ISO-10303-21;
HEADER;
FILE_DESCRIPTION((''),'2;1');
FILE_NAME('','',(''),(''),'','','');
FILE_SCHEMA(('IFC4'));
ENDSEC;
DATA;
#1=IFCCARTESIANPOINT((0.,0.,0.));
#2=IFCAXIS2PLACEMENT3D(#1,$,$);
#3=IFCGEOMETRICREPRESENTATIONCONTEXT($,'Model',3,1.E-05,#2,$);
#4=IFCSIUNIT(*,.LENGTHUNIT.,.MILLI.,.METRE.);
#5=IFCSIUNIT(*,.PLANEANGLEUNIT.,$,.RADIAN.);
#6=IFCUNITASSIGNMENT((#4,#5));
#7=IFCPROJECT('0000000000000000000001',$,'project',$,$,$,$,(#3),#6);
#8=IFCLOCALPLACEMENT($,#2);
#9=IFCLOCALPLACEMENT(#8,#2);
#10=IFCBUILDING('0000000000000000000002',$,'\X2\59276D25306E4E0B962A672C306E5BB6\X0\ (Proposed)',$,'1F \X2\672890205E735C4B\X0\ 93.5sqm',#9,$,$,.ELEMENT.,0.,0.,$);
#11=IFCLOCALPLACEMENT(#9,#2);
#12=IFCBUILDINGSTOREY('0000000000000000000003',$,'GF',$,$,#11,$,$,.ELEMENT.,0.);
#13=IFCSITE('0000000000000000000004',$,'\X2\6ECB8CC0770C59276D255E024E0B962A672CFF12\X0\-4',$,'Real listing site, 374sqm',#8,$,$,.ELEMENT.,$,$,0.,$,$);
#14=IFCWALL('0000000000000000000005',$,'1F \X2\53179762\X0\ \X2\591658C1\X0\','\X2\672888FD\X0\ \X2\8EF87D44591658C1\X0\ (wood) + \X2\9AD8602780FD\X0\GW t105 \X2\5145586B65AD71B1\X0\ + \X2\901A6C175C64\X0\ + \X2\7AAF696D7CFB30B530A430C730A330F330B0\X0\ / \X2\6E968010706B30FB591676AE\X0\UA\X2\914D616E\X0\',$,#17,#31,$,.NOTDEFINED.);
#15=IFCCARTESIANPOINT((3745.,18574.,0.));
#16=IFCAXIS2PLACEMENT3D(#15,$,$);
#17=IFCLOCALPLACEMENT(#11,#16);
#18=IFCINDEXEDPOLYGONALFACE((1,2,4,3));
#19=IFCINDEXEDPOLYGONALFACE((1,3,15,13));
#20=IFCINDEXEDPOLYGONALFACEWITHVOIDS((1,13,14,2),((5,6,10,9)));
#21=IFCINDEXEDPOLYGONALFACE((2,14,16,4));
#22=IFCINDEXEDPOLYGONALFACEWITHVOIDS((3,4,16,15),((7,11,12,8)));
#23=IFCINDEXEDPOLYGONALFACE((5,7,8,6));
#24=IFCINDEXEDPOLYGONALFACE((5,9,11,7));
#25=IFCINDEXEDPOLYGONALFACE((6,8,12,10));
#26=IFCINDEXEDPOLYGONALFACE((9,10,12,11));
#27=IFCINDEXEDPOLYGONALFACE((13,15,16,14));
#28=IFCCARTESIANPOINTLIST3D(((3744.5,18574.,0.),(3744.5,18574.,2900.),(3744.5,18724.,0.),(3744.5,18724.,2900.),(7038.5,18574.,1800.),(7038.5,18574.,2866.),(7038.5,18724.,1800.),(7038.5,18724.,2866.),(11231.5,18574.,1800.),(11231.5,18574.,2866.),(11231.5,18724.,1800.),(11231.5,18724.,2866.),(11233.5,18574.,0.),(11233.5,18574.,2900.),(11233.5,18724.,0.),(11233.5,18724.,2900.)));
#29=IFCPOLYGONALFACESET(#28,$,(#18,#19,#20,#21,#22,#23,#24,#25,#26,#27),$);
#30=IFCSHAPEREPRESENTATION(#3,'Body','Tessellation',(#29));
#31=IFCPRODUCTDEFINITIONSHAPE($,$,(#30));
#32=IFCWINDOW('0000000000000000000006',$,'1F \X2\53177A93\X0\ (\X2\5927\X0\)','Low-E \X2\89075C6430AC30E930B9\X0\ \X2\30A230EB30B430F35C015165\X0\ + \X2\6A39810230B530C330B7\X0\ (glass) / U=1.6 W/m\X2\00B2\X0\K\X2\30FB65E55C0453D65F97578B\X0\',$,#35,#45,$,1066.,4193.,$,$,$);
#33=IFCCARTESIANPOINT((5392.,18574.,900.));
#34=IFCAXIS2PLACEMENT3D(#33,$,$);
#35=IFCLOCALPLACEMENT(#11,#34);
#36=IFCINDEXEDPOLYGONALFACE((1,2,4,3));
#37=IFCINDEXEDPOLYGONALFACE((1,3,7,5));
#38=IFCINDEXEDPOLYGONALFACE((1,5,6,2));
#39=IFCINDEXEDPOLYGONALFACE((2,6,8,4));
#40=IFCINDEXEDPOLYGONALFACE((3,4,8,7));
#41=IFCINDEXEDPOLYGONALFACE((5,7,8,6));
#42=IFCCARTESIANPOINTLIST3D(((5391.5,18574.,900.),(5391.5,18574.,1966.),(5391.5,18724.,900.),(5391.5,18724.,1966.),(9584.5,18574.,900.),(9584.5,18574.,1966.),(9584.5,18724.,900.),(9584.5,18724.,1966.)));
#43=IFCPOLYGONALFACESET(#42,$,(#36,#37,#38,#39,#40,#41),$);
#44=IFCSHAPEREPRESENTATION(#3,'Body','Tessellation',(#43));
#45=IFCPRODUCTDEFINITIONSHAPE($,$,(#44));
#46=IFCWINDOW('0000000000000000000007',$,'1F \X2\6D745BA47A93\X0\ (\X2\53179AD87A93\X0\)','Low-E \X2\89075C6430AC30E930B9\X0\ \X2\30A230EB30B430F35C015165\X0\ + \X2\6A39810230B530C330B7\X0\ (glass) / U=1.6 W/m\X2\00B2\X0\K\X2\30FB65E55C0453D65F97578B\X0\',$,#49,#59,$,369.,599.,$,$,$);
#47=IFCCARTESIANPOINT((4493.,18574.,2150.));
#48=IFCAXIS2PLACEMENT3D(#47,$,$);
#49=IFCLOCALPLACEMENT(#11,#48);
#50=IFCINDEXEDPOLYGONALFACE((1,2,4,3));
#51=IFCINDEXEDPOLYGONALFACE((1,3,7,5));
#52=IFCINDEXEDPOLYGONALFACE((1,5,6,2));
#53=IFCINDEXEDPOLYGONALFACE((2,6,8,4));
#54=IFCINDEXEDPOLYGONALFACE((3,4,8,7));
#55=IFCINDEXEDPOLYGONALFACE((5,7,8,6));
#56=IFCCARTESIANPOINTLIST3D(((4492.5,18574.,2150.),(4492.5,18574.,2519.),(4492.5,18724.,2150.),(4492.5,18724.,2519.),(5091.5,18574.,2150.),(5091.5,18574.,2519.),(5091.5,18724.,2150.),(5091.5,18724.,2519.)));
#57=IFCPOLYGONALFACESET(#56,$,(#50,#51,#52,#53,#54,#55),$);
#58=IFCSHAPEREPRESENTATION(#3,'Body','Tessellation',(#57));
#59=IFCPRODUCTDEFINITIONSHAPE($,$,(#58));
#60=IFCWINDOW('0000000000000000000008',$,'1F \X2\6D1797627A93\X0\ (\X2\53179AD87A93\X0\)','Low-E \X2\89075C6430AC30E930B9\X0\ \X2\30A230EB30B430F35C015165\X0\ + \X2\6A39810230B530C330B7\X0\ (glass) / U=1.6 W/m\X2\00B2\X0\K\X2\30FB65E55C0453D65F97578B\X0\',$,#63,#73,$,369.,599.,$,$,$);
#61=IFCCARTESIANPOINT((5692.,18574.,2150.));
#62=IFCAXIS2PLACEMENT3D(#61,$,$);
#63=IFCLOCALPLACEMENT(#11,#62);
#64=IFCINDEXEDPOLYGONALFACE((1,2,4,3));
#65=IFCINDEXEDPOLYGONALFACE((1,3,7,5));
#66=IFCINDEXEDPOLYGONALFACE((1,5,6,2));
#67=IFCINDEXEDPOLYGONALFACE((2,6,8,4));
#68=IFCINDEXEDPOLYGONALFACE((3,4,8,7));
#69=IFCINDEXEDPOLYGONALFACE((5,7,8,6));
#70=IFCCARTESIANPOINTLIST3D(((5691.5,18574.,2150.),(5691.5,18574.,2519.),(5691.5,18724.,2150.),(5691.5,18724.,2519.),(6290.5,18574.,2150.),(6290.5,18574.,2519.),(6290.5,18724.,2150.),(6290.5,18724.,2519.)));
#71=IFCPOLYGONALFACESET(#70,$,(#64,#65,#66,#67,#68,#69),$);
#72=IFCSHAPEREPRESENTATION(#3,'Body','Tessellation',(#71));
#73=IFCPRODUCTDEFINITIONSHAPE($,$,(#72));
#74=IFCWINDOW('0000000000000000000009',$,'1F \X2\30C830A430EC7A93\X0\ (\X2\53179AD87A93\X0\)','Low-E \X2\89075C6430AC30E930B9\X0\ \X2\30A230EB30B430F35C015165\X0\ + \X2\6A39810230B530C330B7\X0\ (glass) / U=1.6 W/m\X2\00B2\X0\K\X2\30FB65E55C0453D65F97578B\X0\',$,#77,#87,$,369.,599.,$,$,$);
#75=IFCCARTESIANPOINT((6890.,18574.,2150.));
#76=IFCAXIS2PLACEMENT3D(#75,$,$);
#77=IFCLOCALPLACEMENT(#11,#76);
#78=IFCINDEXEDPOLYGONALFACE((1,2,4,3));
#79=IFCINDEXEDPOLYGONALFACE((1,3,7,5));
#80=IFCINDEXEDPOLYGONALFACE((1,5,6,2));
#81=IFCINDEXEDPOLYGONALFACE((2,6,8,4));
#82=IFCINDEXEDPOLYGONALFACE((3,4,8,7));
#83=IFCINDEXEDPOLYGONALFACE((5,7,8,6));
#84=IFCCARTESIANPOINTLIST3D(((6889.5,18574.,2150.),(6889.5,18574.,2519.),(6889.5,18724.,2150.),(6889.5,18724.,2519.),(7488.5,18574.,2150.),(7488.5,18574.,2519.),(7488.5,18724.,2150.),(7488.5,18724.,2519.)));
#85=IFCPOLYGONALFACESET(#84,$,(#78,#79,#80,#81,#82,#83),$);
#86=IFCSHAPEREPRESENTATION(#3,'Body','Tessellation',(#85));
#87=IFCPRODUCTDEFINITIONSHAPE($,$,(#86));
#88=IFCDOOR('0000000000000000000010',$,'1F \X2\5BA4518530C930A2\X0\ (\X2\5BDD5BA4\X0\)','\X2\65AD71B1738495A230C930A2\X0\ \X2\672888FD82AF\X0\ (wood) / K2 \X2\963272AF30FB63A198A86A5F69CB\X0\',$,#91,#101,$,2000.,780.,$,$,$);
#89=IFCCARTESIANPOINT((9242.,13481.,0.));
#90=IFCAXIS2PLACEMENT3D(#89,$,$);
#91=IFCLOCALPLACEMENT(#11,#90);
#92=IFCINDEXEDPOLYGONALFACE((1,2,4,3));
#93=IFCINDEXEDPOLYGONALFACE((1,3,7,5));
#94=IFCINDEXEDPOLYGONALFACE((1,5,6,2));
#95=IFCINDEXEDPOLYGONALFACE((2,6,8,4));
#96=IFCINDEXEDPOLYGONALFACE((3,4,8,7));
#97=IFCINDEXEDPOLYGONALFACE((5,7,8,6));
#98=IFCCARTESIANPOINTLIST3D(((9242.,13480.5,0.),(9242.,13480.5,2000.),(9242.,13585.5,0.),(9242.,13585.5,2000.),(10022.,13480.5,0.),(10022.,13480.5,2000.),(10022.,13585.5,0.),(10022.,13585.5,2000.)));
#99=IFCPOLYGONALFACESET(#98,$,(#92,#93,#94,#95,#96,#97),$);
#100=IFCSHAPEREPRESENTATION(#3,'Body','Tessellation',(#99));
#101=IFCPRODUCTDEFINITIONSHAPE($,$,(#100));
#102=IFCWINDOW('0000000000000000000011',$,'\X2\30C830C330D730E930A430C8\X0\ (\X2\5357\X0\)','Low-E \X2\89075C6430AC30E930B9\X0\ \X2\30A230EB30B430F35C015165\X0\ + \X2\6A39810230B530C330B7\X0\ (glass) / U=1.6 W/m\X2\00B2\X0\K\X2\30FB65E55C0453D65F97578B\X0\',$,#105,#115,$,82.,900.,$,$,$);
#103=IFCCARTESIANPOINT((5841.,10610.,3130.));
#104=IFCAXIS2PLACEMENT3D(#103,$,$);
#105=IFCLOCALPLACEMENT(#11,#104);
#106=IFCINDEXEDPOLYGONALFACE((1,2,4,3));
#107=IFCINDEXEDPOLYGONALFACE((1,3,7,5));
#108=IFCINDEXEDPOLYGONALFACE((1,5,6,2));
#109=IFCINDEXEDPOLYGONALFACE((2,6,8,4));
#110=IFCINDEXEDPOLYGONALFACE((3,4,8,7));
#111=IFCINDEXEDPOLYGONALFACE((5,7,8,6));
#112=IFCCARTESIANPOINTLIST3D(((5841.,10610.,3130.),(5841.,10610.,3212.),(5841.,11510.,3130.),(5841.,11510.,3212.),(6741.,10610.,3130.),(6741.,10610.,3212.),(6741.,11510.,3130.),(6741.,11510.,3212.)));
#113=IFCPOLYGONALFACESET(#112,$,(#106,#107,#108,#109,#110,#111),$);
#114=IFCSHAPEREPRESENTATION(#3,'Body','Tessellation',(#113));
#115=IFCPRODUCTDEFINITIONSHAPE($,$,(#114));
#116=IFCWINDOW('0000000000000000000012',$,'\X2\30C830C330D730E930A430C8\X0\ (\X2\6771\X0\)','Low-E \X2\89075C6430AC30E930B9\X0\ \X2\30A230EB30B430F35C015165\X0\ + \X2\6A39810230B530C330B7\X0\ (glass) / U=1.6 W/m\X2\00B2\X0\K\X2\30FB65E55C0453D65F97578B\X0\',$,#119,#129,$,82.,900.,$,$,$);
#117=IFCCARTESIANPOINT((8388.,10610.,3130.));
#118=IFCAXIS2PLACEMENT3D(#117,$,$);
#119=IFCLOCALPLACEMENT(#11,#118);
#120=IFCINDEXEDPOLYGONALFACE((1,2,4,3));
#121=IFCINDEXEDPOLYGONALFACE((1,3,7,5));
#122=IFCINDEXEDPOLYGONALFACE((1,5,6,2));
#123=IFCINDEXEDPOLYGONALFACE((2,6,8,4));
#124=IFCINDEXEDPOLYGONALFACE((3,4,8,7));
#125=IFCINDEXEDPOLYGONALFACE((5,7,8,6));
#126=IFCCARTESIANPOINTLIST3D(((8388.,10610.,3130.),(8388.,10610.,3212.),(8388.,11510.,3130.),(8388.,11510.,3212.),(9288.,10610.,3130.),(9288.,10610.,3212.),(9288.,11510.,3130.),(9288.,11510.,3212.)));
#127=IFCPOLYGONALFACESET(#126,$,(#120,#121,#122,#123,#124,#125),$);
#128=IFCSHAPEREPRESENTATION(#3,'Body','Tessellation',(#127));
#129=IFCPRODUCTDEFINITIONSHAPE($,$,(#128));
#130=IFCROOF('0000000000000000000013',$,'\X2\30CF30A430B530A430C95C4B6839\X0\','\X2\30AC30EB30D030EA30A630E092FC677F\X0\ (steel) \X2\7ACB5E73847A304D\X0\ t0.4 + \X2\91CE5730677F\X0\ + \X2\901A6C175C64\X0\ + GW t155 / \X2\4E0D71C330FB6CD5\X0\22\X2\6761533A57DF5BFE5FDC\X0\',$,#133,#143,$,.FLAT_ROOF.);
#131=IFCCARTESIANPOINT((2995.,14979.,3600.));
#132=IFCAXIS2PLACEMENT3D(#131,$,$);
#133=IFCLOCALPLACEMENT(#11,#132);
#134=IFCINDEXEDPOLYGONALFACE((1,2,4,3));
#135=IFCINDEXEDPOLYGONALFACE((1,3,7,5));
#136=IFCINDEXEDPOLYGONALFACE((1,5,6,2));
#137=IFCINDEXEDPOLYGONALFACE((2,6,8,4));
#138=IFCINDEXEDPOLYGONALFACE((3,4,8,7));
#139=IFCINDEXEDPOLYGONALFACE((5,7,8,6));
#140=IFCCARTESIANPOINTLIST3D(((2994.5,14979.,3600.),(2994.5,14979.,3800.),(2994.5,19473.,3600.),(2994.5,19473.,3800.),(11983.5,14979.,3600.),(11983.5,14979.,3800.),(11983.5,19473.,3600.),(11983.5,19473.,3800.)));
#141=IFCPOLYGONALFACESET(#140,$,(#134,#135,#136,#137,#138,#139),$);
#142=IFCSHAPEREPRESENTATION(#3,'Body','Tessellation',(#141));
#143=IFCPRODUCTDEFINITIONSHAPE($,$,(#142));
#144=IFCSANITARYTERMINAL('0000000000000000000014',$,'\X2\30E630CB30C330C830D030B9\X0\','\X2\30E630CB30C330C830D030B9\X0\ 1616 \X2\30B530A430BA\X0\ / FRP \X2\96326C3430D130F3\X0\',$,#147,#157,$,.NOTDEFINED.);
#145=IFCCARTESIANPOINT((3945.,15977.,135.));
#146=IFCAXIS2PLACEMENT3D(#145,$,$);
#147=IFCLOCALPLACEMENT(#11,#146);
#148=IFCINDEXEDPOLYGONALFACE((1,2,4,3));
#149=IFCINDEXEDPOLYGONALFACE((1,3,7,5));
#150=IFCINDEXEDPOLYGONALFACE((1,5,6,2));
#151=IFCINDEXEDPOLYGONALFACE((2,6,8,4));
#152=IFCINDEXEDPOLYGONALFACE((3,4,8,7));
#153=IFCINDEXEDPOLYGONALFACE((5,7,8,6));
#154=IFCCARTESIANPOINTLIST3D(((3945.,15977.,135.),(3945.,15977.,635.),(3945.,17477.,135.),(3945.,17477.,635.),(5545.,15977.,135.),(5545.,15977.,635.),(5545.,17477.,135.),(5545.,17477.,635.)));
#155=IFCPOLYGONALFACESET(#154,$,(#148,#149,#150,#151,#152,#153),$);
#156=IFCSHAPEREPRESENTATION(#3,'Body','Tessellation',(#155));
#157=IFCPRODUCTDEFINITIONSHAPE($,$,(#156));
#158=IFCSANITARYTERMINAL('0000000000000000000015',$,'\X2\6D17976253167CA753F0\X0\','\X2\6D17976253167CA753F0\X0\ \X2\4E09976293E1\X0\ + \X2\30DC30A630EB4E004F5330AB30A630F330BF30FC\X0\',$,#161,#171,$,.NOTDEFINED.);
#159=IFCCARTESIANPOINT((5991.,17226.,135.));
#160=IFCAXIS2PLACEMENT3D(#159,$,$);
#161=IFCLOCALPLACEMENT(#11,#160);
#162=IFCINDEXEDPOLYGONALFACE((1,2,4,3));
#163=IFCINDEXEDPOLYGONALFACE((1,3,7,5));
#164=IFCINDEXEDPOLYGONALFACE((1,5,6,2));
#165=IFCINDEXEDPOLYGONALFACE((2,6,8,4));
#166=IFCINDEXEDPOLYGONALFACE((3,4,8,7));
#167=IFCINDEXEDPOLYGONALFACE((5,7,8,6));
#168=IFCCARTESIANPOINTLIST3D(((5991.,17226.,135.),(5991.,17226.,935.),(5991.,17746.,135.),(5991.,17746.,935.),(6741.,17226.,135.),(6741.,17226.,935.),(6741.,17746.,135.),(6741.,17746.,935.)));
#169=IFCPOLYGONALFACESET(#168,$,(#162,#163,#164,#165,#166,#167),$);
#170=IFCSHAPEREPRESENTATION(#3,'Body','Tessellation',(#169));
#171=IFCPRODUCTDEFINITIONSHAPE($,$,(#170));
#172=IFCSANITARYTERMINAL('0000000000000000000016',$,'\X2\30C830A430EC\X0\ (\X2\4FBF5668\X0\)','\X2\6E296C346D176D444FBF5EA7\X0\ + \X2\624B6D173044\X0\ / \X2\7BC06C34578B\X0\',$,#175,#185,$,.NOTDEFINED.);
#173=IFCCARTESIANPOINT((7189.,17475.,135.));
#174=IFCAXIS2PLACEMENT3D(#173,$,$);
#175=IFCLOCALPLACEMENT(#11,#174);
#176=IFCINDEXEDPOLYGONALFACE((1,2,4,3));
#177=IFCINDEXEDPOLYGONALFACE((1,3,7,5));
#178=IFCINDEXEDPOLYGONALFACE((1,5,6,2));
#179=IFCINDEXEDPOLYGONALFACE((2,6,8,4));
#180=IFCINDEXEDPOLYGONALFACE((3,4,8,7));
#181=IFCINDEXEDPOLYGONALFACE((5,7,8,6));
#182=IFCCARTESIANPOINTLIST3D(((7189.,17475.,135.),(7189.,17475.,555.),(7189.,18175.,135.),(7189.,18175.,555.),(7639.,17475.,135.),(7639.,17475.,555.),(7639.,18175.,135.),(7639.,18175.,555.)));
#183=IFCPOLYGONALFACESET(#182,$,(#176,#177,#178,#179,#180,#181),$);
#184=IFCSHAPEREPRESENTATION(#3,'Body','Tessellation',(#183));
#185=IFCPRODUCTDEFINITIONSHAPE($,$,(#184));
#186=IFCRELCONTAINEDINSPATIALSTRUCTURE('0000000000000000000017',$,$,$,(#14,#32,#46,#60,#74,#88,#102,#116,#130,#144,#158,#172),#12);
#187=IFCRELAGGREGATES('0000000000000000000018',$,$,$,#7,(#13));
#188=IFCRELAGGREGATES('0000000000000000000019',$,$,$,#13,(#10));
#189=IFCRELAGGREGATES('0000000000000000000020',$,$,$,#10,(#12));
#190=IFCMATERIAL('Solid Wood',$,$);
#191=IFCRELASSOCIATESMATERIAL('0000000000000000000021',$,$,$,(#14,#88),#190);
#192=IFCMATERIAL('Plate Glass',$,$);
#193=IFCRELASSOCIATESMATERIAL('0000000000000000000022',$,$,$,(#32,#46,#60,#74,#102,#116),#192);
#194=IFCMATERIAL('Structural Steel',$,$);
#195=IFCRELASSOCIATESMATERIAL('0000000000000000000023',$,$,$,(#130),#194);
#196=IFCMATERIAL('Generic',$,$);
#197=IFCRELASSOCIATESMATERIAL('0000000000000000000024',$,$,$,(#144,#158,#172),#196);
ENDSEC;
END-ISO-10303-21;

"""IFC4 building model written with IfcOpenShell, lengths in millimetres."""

from ifc_helpers import new_model, si_unit, frame, frame_2d, origin, place, context, project, spatial, rectangle, extrude, material, element, fill, save


model = new_model("IFC4")

# Units and contexts
model_context = context("Model", 3, precision=1e-05, world=origin())
ifc_project = project(units=[si_unit("LENGTHUNIT", "METRE", prefix="MILLI"), si_unit("PLANEANGLEUNIT", "RADIAN")], contexts=[model_context])

# Site, building, storey
site_placement = place(None, origin())
site = spatial("IfcSite", under=ifc_project, at=site_placement, Name="滋賀県大津市下阪本２-4", ObjectType="Real listing site, 374sqm", CompositionType="ELEMENT", RefElevation=0.0)
building_placement = place(site_placement, origin())
building = spatial("IfcBuilding", under=site, at=building_placement, Name="大津の下阪本の家 (Proposed)", ObjectType="1F 木造平屋 93.5sqm", CompositionType="ELEMENT", ElevationOfRefHeight=0.0, ElevationOfTerrain=0.0)
storey_placement = place(building_placement, origin())
storey = spatial("IfcBuildingStorey", under=building, at=storey_placement, Name="GF", CompositionType="ELEMENT", Elevation=0.0)

# Shared definitions
ifc_material_1 = material(Name="Solid Wood")

# Wall, openings, windows
wall_1_placement = place(storey_placement, frame((3745.0, 18574.0, 0.0)))
wall_1 = element("IfcWall", 1, at=wall_1_placement, inside=storey, material=ifc_material_1, Name="1F 北面 外壁", Description="木製 軸組外壁 (wood) + 高性能GW t105 充填断熱 + 通気層 + 窯業系サイディング / 準耐火・外皮UA配慮", PredefinedType="NOTDEFINED", context=model_context, shape_type="SweptSolid", body=[
    extrude(rectangle(XDim=7489.0, YDim=150.0, at=frame_2d((3744.0, 75.0))), frame((3745.0, 18574.0, 0.0)), (0.0, 0.0, 1.0), 2900.0),
])
opening_1_placement = place(storey_placement, frame((5392.0, 18574.0, 900.0)))
opening_1 = element("IfcOpeningElement", 2, at=opening_1_placement, cuts=wall_1, PredefinedType="NOTDEFINED", context=model_context, shape_type="SweptSolid", body=[
    extrude(rectangle(XDim=4193.0, YDim=150.0, at=frame_2d((2096.0, 75.0))), frame((5392.0, 18574.0, 900.0)), (0.0, 0.0, 1.0), 1066.0),
])
opening_2_placement = place(storey_placement, frame((4493.0, 18574.0, 2150.0)))
opening_2 = element("IfcOpeningElement", 3, at=opening_2_placement, cuts=wall_1, PredefinedType="NOTDEFINED", context=model_context, shape_type="SweptSolid", body=[
    extrude(rectangle(XDim=599.0, YDim=150.0, at=frame_2d((299.0, 75.0))), frame((4493.0, 18574.0, 2150.0)), (0.0, 0.0, 1.0), 369.0),
])
opening_3_placement = place(storey_placement, frame((5692.0, 18574.0, 2150.0)))
opening_3 = element("IfcOpeningElement", 4, at=opening_3_placement, cuts=wall_1, PredefinedType="NOTDEFINED", context=model_context, shape_type="SweptSolid", body=[
    extrude(rectangle(XDim=599.0, YDim=150.0, at=frame_2d((299.0, 75.0))), frame((5692.0, 18574.0, 2150.0)), (0.0, 0.0, 1.0), 369.0),
])
opening_4_placement = place(storey_placement, frame((6890.0, 18574.0, 2150.0)))
opening_4 = element("IfcOpeningElement", 5, at=opening_4_placement, cuts=wall_1, PredefinedType="NOTDEFINED", context=model_context, shape_type="SweptSolid", body=[
    extrude(rectangle(XDim=599.0, YDim=150.0, at=frame_2d((299.0, 75.0))), frame((6890.0, 18574.0, 2150.0)), (0.0, 0.0, 1.0), 369.0),
])
ifc_material_2 = material(Name="Plate Glass")
window_1_placement = place(storey_placement, frame((5392.0, 18574.0, 900.0)))
window_1 = element("IfcWindow", 6, at=window_1_placement, inside=storey, material=ifc_material_2, Name="1F 北窓 (大)", Description="Low-E 複層ガラス アルゴン封入 + 樹脂サッシ (glass) / U=1.6 W/m²K・日射取得型", OverallHeight=1066.0, OverallWidth=4193.0, context=model_context, shape_type="SweptSolid", body=[
    extrude(rectangle(XDim=4193.0, YDim=150.0, at=frame_2d((2096.0, 75.0))), frame((5392.0, 18574.0, 900.0)), (0.0, 0.0, 1.0), 1066.0),
])
fill(opening_1, window_1)
window_2_placement = place(storey_placement, frame((4493.0, 18574.0, 2150.0)))
window_2 = element("IfcWindow", 7, at=window_2_placement, inside=storey, material=ifc_material_2, Name="1F 浴室窓 (北高窓)", Description="Low-E 複層ガラス アルゴン封入 + 樹脂サッシ (glass) / U=1.6 W/m²K・日射取得型", OverallHeight=369.0, OverallWidth=599.0, context=model_context, shape_type="SweptSolid", body=[
    extrude(rectangle(XDim=599.0, YDim=150.0, at=frame_2d((299.0, 75.0))), frame((4493.0, 18574.0, 2150.0)), (0.0, 0.0, 1.0), 369.0),
])
fill(opening_2, window_2)
window_3_placement = place(storey_placement, frame((5692.0, 18574.0, 2150.0)))
window_3 = element("IfcWindow", 8, at=window_3_placement, inside=storey, material=ifc_material_2, Name="1F 洗面窓 (北高窓)", Description="Low-E 複層ガラス アルゴン封入 + 樹脂サッシ (glass) / U=1.6 W/m²K・日射取得型", OverallHeight=369.0, OverallWidth=599.0, context=model_context, shape_type="SweptSolid", body=[
    extrude(rectangle(XDim=599.0, YDim=150.0, at=frame_2d((299.0, 75.0))), frame((5692.0, 18574.0, 2150.0)), (0.0, 0.0, 1.0), 369.0),
])
fill(opening_3, window_3)
window_4_placement = place(storey_placement, frame((6890.0, 18574.0, 2150.0)))
window_4 = element("IfcWindow", 9, at=window_4_placement, inside=storey, material=ifc_material_2, Name="1F トイレ窓 (北高窓)", Description="Low-E 複層ガラス アルゴン封入 + 樹脂サッシ (glass) / U=1.6 W/m²K・日射取得型", OverallHeight=369.0, OverallWidth=599.0, context=model_context, shape_type="SweptSolid", body=[
    extrude(rectangle(XDim=599.0, YDim=150.0, at=frame_2d((299.0, 75.0))), frame((6890.0, 18574.0, 2150.0)), (0.0, 0.0, 1.0), 369.0),
])
fill(opening_4, window_4)

# Door
door_1_placement = place(storey_placement, frame((9242.0, 13481.0, 0.0)))
element("IfcDoor", 10, at=door_1_placement, inside=storey, material=ifc_material_1, Name="1F 室内ドア (寝室)", Description="断熱玄関ドア 木製芯 (wood) / K2 防犯・採風機構", OverallHeight=2000.0, OverallWidth=780.0, context=model_context, shape_type="SweptSolid", body=[
    extrude(rectangle(XDim=780.0, YDim=105.0, at=frame_2d((390.0, 52.0))), frame((9242.0, 13481.0, 0.0)), (0.0, 0.0, 1.0), 2000.0),
])

# Windows
window_5_placement = place(storey_placement, frame((5841.0, 10610.0, 3130.0)))
element("IfcWindow", 11, at=window_5_placement, inside=storey, material=ifc_material_2, Name="トップライト (南)", Description="Low-E 複層ガラス アルゴン封入 + 樹脂サッシ (glass) / U=1.6 W/m²K・日射取得型", OverallHeight=82.0, OverallWidth=900.0, context=model_context, shape_type="SweptSolid", body=[
    extrude(rectangle(XDim=900.0, YDim=900.0, at=frame_2d((450.0, 450.0))), frame((5841.0, 10610.0, 3130.0)), (0.0, 0.0, 1.0), 82.0),
])
window_6_placement = place(storey_placement, frame((8388.0, 10610.0, 3130.0)))
element("IfcWindow", 12, at=window_6_placement, inside=storey, material=ifc_material_2, Name="トップライト (東)", Description="Low-E 複層ガラス アルゴン封入 + 樹脂サッシ (glass) / U=1.6 W/m²K・日射取得型", OverallHeight=82.0, OverallWidth=900.0, context=model_context, shape_type="SweptSolid", body=[
    extrude(rectangle(XDim=900.0, YDim=900.0, at=frame_2d((450.0, 450.0))), frame((8388.0, 10610.0, 3130.0)), (0.0, 0.0, 1.0), 82.0),
])

# Roof
ifc_material_3 = material(Name="Structural Steel")
roof_placement = place(storey_placement, frame((2995.0, 14979.0, 3600.0)))
element("IfcRoof", 13, at=roof_placement, inside=storey, material=ifc_material_3, Name="ハイサイド屋根", Description="ガルバリウム鋼板 (steel) 立平葺き t0.4 + 野地板 + 通気層 + GW t155 / 不燃・法22条区域対応", PredefinedType="FLAT_ROOF", context=model_context, shape_type="SweptSolid", body=[
    extrude(rectangle(XDim=8989.0, YDim=4494.0, at=frame_2d((4494.0, 2247.0))), frame((2995.0, 14979.0, 3600.0)), (0.0, 0.0, 1.0), 200.0),
])

# Sanitary terminals
ifc_material_4 = material(Name="Generic")
sanitary_terminal_1_placement = place(storey_placement, frame((3945.0, 15977.0, 135.0)))
element("IfcSanitaryTerminal", 14, at=sanitary_terminal_1_placement, inside=storey, material=ifc_material_4, Name="ユニットバス", Description="ユニットバス 1616 サイズ / FRP 防水パン", PredefinedType="NOTDEFINED", context=model_context, shape_type="SweptSolid", body=[
    extrude(rectangle(XDim=1600.0, YDim=1500.0, at=frame_2d((800.0, 750.0))), frame((3945.0, 15977.0, 135.0)), (0.0, 0.0, 1.0), 500.0),
])
sanitary_terminal_2_placement = place(storey_placement, frame((5991.0, 17226.0, 135.0)))
element("IfcSanitaryTerminal", 15, at=sanitary_terminal_2_placement, inside=storey, material=ifc_material_4, Name="洗面化粧台", Description="洗面化粧台 三面鏡 + ボウル一体カウンター", PredefinedType="NOTDEFINED", context=model_context, shape_type="SweptSolid", body=[
    extrude(rectangle(XDim=750.0, YDim=520.0, at=frame_2d((375.0, 260.0))), frame((5991.0, 17226.0, 135.0)), (0.0, 0.0, 1.0), 800.0),
])
sanitary_terminal_3_placement = place(storey_placement, frame((7189.0, 17475.0, 135.0)))
element("IfcSanitaryTerminal", 16, at=sanitary_terminal_3_placement, inside=storey, material=ifc_material_4, Name="トイレ (便器)", Description="温水洗浄便座 + 手洗い / 節水型", PredefinedType="NOTDEFINED", context=model_context, shape_type="SweptSolid", body=[
    extrude(rectangle(XDim=450.0, YDim=700.0, at=frame_2d((225.0, 350.0))), frame((7189.0, 17475.0, 135.0)), (0.0, 0.0, 1.0), 420.0),
])

save(model, "model.ifc")
